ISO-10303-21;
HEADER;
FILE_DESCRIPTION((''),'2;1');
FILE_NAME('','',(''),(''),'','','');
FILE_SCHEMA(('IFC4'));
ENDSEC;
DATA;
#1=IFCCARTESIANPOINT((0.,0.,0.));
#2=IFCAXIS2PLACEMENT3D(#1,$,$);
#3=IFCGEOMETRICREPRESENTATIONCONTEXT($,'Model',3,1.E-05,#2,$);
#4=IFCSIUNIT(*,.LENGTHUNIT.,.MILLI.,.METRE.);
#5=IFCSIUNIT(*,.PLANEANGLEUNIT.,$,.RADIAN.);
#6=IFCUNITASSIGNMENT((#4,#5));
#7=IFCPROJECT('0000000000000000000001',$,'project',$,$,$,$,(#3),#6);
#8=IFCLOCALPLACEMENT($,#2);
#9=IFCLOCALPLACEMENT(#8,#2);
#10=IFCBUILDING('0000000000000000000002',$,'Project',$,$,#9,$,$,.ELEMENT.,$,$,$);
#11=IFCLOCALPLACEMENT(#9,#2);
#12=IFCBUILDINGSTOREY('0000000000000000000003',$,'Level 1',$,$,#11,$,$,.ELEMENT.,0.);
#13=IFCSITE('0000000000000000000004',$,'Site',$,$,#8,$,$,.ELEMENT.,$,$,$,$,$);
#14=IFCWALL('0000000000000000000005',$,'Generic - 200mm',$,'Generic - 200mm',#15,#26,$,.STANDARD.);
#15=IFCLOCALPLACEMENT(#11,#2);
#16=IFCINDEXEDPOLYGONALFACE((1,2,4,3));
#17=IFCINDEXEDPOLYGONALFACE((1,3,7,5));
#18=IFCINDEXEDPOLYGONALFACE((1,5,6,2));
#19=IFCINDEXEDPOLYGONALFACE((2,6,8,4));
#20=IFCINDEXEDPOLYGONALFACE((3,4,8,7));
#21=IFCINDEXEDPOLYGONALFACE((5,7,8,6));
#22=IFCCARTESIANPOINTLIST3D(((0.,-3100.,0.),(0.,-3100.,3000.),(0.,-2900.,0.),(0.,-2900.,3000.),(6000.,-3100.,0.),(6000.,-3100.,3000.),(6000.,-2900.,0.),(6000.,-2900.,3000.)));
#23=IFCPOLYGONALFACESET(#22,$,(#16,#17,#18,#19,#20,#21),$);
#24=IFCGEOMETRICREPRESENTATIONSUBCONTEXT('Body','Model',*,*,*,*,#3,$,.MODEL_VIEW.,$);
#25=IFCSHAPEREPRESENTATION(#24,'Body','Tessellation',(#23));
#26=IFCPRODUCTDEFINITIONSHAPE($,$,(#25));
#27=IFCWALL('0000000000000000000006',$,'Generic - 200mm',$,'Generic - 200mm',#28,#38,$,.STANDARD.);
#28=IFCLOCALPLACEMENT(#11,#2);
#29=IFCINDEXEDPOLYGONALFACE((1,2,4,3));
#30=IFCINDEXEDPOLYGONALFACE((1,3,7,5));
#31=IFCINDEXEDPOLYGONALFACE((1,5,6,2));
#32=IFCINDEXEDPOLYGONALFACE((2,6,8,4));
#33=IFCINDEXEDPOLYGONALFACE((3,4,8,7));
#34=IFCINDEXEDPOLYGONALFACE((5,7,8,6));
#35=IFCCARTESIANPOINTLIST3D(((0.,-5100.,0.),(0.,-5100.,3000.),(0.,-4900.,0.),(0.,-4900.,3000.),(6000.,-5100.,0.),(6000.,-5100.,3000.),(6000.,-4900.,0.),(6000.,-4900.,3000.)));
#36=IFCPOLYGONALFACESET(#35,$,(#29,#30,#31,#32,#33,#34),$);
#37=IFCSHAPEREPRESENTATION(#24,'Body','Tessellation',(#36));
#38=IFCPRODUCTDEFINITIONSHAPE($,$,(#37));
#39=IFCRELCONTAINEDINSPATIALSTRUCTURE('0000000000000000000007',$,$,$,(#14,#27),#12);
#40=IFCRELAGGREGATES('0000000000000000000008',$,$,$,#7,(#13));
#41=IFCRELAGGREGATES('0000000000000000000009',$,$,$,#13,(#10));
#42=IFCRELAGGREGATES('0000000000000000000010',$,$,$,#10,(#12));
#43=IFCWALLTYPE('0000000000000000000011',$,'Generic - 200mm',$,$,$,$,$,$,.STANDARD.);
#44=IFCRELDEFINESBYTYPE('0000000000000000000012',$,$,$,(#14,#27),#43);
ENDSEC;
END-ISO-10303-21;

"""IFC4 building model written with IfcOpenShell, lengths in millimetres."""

from ifc_helpers import new_model, si_unit, frame, origin, place, context, subcontext, project, spatial, polyline, outline, extrude, type_object, element, save


model = new_model("IFC4")

# Units and contexts
model_context = context("Model", 3, precision=1e-05, world=origin())
body_context = subcontext(model_context, "Body", "Model", "MODEL_VIEW")
ifc_project = project(units=[si_unit("LENGTHUNIT", "METRE", prefix="MILLI"), si_unit("PLANEANGLEUNIT", "RADIAN")], contexts=[model_context])

# Site, building, storey
site_placement = place(None, origin())
site = spatial("IfcSite", under=ifc_project, at=site_placement, Name="Site", CompositionType="ELEMENT")
building_placement = place(site_placement, origin())
building = spatial("IfcBuilding", under=site, at=building_placement, Name="Project", CompositionType="ELEMENT")
storey_placement = place(building_placement, origin())
storey = spatial("IfcBuildingStorey", under=building, at=storey_placement, Name="Level 1", CompositionType="ELEMENT", Elevation=0.0)

# Walls
wall_type = type_object("IfcWallType", Name="Generic - 200mm", PredefinedType="STANDARD")
for number, where, z_axis, x_axis, name in (
    (1, (0.0, -3000.0, 0.0), (0.0, 0.0, 1.0), (1.0, 0.0, 0.0), "Generic - 200mm"),
    (2, (0.0, -5000.0, 0.0), (0.0, 0.0, 1.0), (1.0, 0.0, 0.0), "Generic - 200mm"),
):
    element("IfcWall", number, at=place(storey_placement, frame(where, z_axis=z_axis, x_axis=x_axis)), inside=storey, type_object=wall_type, Name=name, ObjectType="Generic - 200mm", PredefinedType="STANDARD", context=body_context, shape_type="SweptSolid", body=[
        extrude(outline(polyline([(0.0, -100.0), (0.0, 100.0), (6000.0, 100.0), (6000.0, -100.0), (0.0, -100.0)])), origin(), (0.0, 0.0, 1.0), 3000.0),
    ])

save(model, "model.ifc")
